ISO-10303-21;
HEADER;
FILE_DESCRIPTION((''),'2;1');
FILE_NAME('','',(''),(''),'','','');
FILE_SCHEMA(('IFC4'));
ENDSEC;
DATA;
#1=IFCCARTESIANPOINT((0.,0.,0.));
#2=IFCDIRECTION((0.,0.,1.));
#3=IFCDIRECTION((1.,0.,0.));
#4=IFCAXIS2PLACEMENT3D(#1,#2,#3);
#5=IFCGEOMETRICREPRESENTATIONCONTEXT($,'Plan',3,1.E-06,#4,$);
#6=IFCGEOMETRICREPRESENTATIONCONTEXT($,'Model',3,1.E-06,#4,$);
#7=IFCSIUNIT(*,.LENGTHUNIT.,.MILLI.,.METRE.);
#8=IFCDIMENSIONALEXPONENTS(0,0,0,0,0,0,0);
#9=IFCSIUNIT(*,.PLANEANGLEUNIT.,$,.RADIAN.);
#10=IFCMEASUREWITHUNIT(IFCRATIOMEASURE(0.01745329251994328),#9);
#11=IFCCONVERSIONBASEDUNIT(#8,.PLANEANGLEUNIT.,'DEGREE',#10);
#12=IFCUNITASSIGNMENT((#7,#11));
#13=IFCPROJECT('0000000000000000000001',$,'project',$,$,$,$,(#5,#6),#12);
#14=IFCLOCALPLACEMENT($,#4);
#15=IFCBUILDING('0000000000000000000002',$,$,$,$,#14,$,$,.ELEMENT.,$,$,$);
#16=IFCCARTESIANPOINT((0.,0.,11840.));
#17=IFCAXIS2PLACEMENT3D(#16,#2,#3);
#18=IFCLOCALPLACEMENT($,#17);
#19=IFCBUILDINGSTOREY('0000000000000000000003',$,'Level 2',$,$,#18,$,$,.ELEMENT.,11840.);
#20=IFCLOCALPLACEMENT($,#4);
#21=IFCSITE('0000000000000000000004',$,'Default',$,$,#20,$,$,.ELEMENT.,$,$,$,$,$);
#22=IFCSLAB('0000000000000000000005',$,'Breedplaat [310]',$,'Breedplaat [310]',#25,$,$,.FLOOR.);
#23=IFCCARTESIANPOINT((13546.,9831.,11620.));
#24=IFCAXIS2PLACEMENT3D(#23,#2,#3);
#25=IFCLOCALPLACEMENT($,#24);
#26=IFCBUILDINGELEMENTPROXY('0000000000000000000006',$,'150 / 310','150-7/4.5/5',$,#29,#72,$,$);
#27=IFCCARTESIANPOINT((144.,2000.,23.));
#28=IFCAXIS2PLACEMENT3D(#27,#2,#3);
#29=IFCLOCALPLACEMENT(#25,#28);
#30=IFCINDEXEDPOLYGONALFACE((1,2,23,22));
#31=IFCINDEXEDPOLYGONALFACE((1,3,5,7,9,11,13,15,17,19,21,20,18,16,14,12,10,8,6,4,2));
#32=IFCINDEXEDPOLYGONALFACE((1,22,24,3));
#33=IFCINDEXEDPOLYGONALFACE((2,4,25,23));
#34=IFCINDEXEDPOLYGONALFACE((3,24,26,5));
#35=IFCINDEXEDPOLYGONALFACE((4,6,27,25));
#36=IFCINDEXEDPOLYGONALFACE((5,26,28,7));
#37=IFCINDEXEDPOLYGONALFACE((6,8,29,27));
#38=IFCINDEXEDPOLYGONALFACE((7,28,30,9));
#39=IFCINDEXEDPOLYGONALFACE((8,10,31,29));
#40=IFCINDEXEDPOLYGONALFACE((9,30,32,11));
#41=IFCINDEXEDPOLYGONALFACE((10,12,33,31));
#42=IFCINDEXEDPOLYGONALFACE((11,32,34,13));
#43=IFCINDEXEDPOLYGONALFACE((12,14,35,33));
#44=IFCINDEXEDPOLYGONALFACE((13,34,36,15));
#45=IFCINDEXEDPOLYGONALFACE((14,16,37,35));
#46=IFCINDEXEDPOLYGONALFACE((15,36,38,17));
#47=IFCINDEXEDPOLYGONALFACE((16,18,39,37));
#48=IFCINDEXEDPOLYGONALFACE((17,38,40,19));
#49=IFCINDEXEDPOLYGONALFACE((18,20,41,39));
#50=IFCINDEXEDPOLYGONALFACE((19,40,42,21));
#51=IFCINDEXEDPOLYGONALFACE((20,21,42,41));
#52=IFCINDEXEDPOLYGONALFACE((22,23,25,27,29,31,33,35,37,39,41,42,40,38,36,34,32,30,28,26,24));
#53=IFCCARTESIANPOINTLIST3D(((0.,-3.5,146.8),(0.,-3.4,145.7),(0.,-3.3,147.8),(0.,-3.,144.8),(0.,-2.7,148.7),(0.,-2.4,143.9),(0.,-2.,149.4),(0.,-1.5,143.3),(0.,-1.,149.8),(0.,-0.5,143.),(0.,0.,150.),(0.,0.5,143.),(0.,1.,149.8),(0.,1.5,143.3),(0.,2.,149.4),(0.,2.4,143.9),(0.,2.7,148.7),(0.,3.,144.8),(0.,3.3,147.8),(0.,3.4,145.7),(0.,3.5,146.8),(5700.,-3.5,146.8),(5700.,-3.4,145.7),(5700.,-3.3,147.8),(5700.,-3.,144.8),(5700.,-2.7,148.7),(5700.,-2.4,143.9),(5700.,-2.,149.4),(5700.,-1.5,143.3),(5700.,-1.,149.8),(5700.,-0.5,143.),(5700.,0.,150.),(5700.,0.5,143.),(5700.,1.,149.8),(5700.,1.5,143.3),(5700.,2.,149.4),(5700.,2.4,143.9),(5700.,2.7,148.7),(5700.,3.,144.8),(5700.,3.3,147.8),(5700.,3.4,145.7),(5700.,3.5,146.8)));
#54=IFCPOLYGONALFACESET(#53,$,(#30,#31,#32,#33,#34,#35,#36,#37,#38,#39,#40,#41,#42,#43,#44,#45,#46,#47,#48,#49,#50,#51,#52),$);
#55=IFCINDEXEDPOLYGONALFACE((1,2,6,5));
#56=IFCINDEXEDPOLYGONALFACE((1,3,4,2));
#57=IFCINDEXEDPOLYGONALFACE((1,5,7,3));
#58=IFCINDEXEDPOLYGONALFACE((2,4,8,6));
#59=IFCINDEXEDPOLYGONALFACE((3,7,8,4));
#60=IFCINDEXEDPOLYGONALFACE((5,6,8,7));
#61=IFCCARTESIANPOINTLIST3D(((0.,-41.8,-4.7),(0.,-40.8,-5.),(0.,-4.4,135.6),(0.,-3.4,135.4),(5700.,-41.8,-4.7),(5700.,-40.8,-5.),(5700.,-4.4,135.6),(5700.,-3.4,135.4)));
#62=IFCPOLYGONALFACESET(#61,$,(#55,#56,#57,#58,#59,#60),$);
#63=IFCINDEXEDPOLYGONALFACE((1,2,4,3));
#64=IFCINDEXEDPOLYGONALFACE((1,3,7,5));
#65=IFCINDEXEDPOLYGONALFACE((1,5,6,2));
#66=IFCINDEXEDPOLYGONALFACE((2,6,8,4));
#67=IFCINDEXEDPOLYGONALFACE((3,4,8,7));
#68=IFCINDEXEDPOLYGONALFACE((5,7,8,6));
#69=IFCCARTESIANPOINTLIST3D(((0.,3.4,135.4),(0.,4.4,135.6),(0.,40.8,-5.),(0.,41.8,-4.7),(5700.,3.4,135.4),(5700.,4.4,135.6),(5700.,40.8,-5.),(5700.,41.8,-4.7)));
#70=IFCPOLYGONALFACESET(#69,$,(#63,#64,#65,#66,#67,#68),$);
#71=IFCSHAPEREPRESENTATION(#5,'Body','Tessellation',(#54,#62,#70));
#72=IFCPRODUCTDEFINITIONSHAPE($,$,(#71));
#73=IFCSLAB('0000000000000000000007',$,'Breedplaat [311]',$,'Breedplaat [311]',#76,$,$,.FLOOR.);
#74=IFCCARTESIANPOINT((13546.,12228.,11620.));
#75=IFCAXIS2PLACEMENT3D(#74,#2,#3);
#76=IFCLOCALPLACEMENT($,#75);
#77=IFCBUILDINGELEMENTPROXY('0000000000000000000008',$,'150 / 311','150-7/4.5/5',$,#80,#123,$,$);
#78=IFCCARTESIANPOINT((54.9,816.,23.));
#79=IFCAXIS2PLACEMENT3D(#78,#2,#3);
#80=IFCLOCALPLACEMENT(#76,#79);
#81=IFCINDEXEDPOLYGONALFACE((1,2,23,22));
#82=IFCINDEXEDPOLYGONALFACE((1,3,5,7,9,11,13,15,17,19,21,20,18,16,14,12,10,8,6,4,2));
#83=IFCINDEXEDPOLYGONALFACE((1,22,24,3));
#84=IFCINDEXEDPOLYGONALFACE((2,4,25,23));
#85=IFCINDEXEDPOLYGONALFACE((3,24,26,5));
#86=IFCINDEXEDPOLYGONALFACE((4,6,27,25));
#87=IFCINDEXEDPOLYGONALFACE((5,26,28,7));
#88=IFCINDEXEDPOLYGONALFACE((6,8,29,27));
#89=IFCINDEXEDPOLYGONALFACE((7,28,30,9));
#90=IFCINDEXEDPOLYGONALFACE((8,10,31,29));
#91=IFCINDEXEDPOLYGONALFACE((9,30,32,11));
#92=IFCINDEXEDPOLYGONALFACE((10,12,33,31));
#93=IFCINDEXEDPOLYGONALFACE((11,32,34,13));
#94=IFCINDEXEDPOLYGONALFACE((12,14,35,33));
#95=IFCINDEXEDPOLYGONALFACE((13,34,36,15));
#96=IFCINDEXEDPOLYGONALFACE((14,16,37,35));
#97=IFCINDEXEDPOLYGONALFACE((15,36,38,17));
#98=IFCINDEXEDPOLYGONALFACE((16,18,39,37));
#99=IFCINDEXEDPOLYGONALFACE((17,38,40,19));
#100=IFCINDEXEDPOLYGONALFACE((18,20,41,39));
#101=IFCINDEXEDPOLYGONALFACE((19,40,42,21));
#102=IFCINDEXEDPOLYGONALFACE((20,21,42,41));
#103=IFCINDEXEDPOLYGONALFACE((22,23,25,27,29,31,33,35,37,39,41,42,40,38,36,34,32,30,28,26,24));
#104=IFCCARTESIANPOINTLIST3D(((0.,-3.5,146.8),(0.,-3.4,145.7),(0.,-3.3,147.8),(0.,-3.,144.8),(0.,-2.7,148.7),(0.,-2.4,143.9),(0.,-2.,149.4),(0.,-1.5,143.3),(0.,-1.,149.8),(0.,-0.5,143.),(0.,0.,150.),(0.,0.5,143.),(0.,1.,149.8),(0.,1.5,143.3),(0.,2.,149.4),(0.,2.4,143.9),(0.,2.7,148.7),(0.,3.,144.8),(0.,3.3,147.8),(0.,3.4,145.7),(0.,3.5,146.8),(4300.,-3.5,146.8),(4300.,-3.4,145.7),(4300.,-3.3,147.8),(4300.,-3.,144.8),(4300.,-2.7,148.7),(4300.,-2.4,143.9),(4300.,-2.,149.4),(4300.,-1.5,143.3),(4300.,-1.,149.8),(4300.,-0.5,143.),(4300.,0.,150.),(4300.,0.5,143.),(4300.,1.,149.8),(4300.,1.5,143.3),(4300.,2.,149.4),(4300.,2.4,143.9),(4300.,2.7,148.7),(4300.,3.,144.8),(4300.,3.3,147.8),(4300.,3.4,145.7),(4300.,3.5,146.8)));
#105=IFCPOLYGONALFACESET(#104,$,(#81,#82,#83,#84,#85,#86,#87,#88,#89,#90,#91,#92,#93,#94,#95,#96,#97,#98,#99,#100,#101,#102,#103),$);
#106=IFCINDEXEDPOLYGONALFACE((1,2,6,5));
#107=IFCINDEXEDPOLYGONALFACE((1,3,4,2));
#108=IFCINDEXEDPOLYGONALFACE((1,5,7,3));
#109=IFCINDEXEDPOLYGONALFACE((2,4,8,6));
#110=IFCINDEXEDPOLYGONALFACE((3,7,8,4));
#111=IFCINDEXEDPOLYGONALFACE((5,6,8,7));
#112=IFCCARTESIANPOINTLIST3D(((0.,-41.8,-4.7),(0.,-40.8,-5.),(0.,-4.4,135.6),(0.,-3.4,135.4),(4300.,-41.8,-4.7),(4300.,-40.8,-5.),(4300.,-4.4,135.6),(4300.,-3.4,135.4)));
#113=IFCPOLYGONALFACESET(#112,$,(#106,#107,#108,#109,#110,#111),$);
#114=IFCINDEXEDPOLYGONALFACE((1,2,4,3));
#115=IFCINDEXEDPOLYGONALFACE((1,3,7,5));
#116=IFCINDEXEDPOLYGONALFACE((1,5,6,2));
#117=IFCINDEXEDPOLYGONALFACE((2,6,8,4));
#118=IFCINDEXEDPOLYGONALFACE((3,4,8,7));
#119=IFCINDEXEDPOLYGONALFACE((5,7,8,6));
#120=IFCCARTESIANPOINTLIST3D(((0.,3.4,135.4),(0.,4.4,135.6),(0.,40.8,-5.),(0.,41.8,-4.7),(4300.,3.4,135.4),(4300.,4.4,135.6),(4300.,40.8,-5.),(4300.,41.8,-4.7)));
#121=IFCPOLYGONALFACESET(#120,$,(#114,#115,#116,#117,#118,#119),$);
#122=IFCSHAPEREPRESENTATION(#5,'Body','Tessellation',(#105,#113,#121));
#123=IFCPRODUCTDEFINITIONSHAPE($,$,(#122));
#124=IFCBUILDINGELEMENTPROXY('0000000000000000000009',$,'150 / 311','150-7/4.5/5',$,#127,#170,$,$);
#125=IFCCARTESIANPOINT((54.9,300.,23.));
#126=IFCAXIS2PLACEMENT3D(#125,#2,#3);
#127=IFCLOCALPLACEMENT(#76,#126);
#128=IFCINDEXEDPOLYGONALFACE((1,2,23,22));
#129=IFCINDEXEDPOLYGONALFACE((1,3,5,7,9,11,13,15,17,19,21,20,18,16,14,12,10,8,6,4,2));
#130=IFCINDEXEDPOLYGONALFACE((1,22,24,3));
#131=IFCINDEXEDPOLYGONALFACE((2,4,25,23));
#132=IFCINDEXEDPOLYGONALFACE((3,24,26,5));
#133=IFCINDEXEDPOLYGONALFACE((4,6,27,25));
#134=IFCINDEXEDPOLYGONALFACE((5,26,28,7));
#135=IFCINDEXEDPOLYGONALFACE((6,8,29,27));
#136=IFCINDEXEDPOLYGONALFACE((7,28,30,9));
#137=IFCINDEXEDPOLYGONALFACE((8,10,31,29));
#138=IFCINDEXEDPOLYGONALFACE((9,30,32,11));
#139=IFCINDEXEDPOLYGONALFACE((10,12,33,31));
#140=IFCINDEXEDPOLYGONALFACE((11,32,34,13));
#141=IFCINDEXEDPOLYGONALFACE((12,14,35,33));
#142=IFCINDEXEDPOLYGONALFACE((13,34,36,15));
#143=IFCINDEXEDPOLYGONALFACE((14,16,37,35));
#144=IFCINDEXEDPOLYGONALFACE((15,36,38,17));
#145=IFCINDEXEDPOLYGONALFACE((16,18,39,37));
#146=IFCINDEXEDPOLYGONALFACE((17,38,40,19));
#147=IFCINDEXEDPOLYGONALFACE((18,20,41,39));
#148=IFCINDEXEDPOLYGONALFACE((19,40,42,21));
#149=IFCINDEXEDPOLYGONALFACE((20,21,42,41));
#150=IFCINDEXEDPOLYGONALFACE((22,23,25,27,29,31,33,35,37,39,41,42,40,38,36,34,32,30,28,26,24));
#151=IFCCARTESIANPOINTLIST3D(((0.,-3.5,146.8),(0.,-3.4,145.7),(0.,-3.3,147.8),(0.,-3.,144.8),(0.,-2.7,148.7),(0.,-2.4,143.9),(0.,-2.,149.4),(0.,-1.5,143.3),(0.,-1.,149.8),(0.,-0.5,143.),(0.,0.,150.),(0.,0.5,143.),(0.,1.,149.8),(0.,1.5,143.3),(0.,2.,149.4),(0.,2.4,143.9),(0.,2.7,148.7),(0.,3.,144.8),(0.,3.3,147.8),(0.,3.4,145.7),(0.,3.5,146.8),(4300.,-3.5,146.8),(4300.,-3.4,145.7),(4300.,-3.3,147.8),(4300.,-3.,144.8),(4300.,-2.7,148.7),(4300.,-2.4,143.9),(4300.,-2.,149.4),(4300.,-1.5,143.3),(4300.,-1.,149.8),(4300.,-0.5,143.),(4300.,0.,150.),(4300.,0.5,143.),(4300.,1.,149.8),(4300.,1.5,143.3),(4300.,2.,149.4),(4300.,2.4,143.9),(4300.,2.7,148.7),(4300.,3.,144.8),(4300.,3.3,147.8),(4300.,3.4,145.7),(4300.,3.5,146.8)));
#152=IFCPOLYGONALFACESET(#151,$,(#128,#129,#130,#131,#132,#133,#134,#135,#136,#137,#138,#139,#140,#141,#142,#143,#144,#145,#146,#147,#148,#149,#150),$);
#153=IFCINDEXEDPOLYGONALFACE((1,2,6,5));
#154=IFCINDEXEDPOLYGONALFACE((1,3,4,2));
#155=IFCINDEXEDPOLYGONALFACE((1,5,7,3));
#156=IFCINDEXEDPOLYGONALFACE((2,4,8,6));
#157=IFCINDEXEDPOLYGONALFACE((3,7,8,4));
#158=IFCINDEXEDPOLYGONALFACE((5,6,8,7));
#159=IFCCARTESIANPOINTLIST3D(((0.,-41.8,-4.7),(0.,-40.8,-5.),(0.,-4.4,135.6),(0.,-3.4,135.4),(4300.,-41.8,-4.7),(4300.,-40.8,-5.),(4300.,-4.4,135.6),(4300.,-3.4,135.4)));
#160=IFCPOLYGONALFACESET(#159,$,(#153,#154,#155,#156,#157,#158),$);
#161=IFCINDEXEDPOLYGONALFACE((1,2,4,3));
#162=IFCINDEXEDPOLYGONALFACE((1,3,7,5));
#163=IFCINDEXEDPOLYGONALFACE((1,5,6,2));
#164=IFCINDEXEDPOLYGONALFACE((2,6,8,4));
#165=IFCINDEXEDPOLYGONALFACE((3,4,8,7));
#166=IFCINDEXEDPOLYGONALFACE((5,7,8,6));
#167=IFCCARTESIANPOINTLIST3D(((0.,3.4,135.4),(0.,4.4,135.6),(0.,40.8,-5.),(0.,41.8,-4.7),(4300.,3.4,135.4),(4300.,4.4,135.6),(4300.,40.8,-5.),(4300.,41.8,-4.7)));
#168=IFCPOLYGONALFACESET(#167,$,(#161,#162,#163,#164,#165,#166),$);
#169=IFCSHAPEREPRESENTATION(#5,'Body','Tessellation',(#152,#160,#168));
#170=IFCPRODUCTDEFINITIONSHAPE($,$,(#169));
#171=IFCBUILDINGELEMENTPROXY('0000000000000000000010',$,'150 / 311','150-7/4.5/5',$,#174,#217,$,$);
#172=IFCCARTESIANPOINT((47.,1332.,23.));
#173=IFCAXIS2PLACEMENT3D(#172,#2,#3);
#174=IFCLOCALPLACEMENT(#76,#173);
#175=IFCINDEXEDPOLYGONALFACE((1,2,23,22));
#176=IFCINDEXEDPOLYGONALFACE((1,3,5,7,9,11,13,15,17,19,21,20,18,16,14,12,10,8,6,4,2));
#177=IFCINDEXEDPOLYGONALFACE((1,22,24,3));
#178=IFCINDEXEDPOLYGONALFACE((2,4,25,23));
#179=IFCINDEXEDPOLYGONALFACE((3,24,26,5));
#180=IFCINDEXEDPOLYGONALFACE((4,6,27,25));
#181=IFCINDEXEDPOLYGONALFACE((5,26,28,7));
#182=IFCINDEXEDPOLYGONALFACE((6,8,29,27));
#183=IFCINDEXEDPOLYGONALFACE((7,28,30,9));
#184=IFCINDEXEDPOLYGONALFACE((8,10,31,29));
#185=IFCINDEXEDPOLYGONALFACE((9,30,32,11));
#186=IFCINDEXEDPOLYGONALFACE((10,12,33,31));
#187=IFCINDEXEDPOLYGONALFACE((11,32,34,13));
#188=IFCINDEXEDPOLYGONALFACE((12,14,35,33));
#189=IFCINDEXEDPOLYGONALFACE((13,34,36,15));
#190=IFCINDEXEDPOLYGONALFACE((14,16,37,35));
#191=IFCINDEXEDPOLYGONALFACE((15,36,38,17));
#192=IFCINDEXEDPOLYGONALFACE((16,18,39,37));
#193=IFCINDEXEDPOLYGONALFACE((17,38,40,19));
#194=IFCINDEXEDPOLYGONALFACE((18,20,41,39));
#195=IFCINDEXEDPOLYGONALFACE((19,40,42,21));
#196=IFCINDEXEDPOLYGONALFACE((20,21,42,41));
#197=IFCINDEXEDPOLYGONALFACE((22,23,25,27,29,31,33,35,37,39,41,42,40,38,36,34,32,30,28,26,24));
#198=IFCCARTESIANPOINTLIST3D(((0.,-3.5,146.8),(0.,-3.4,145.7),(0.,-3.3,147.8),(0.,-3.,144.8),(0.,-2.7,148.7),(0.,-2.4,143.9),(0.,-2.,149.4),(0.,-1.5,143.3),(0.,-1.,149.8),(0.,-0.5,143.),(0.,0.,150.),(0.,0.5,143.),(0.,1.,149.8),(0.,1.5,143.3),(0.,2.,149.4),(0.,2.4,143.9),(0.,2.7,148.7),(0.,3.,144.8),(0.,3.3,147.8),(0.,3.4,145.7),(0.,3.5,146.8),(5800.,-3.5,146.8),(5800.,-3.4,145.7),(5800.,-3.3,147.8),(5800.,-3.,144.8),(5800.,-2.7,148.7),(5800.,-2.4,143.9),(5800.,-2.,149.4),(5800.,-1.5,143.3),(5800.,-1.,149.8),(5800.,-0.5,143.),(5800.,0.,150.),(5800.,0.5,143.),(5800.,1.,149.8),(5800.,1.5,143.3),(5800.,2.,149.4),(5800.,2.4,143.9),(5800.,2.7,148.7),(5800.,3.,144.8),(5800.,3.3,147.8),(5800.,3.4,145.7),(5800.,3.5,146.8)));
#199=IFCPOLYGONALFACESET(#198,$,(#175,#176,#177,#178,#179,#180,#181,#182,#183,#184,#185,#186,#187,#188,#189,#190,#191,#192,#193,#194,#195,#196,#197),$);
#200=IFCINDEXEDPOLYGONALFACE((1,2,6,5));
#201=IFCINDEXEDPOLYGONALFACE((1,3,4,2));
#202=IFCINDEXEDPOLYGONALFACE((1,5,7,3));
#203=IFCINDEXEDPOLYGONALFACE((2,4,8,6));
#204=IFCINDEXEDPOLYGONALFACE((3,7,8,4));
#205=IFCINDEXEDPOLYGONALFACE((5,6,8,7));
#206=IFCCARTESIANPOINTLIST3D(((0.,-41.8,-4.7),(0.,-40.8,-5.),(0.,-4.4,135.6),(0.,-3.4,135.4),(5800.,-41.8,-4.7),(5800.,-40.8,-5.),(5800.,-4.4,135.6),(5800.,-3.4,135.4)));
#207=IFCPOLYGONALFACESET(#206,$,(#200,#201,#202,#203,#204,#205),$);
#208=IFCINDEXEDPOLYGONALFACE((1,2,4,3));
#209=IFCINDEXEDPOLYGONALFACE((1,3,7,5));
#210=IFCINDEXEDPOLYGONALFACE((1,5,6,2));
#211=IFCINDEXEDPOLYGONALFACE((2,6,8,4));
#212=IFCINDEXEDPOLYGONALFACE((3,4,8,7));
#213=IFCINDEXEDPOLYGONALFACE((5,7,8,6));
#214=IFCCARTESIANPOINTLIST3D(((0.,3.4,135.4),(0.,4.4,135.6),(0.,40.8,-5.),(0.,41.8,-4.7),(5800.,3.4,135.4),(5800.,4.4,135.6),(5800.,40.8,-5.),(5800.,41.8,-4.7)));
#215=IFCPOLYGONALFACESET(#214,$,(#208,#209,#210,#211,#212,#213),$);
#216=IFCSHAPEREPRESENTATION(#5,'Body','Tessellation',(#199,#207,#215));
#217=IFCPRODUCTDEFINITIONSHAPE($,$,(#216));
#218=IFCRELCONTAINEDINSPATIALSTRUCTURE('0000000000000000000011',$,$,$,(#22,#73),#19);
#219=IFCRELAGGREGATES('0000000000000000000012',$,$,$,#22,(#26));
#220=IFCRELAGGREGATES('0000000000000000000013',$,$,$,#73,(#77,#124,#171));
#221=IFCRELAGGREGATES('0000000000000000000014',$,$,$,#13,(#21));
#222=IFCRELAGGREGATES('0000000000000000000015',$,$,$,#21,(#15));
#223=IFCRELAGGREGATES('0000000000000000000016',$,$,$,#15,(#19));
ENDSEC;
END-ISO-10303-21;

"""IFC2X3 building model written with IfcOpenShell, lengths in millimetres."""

from ifc_helpers import new_model, entity, si_unit, converted_unit, frame, origin_with_axes, origin_2d_with_axis, place, context, project, spatial, rectangle, circle, extrude, element, aggregate, save


model = new_model("IFC2X3")

# Units and contexts
plan_context = context("Plan", 3, precision=1e-06, world=origin_with_axes())
model_context = context("Model", 3, precision=1e-06, world=origin_with_axes())
ifc_project = project(units=[si_unit("LENGTHUNIT", "METRE", prefix="MILLI"), converted_unit("PLANEANGLEUNIT", "DEGREE", entity("IfcRatioMeasure", 0.01745329251994328), si_unit("PLANEANGLEUNIT", "RADIAN"), dimensions=[0, 0, 0, 0, 0, 0, 0])], contexts=[plan_context, model_context])

# Site, building, storey
site_placement = place(None, origin_with_axes())
site = spatial("IfcSite", under=ifc_project, at=site_placement, Name="Default", CompositionType="ELEMENT")
building_placement = place(None, origin_with_axes())
building = spatial("IfcBuilding", under=site, at=building_placement, CompositionType="ELEMENT")
storey_placement = place(None, frame((0.0, 0.0, 11840.0), z_axis=(0.0, 0.0, 1.0), x_axis=(1.0, 0.0, 0.0)))
storey = spatial("IfcBuildingStorey", under=building, at=storey_placement, Name="Level 2", CompositionType="ELEMENT", Elevation=11840.0)

# Slabs, building element proxies
slab_1_placement = place(None, frame((13546.0, 9831.0, 11620.0), z_axis=(0.0, 0.0, 1.0), x_axis=(1.0, 0.0, 0.0)))
slab_1 = element("IfcSlab", 1, at=slab_1_placement, inside=storey, Name="Breedplaat [310]", ObjectType="Breedplaat [310]", PredefinedType="FLOOR")
proxy_1_placement = place(slab_1_placement, frame((144.0, 2000.0, 23.0), z_axis=(0.0, 0.0, 1.0), x_axis=(1.0, 0.0, 0.0)))
proxy_1 = element("IfcBuildingElementProxy", 2, at=proxy_1_placement, Name="150 / 310", Description="150-7/4.5/5", context=plan_context, shape_type="SweptSolid", body=[
    extrude(circle(Radius=3.5, at=origin_2d_with_axis()), frame((0.0, 0.0, 146.5), z_axis=(1.0, 0.0, 0.0), x_axis=(0.0, 0.0, 1.0)), (0.0, 0.0, 1.0), 5700.0),
    extrude(rectangle(XDim=145.2, YDim=1.0, at=origin_2d_with_axis()), frame((0.0, -22.6, 65.3), z_axis=(1.0, 0.0, 0.0), x_axis=(0.0, 0.257663, 0.966235)), (0.0, 0.0, 1.0), 5700.0),
    extrude(rectangle(XDim=145.2, YDim=1.0, at=origin_2d_with_axis()), frame((0.0, 22.6, 65.3), z_axis=(1.0, 0.0, 0.0), x_axis=(0.0, -0.257663, 0.966235)), (0.0, 0.0, 1.0), 5700.0),
])
aggregate(slab_1, [proxy_1])
slab_2_placement = place(None, frame((13546.0, 12228.0, 11620.0), z_axis=(0.0, 0.0, 1.0), x_axis=(1.0, 0.0, 0.0)))
slab_2 = element("IfcSlab", 3, at=slab_2_placement, inside=storey, Name="Breedplaat [311]", ObjectType="Breedplaat [311]", PredefinedType="FLOOR")
proxy_2_placement = place(slab_2_placement, frame((54.9, 816.0, 23.0), z_axis=(0.0, 0.0, 1.0), x_axis=(1.0, 0.0, 0.0)))
proxy_2 = element("IfcBuildingElementProxy", 4, at=proxy_2_placement, Name="150 / 311", Description="150-7/4.5/5", context=plan_context, shape_type="SweptSolid", body=[
    extrude(circle(Radius=3.5, at=origin_2d_with_axis()), frame((0.0, 0.0, 146.5), z_axis=(1.0, 0.0, 0.0), x_axis=(0.0, 0.0, 1.0)), (0.0, 0.0, 1.0), 4300.0),
    extrude(rectangle(XDim=145.2, YDim=1.0, at=origin_2d_with_axis()), frame((0.0, -22.6, 65.3), z_axis=(1.0, 0.0, 0.0), x_axis=(0.0, 0.257663, 0.966235)), (0.0, 0.0, 1.0), 4300.0),
    extrude(rectangle(XDim=145.2, YDim=1.0, at=origin_2d_with_axis()), frame((0.0, 22.6, 65.3), z_axis=(1.0, 0.0, 0.0), x_axis=(0.0, -0.257663, 0.966235)), (0.0, 0.0, 1.0), 4300.0),
])
proxy_3_placement = place(slab_2_placement, frame((54.9, 300.0, 23.0), z_axis=(0.0, 0.0, 1.0), x_axis=(1.0, 0.0, 0.0)))
proxy_3 = element("IfcBuildingElementProxy", 5, at=proxy_3_placement, Name="150 / 311", Description="150-7/4.5/5", context=plan_context, shape_type="SweptSolid", body=[
    extrude(circle(Radius=3.5, at=origin_2d_with_axis()), frame((0.0, 0.0, 146.5), z_axis=(1.0, 0.0, 0.0), x_axis=(0.0, 0.0, 1.0)), (0.0, 0.0, 1.0), 4300.0),
    extrude(rectangle(XDim=145.2, YDim=1.0, at=origin_2d_with_axis()), frame((0.0, -22.6, 65.3), z_axis=(1.0, 0.0, 0.0), x_axis=(0.0, 0.257663, 0.966235)), (0.0, 0.0, 1.0), 4300.0),
    extrude(rectangle(XDim=145.2, YDim=1.0, at=origin_2d_with_axis()), frame((0.0, 22.6, 65.3), z_axis=(1.0, 0.0, 0.0), x_axis=(0.0, -0.257663, 0.966235)), (0.0, 0.0, 1.0), 4300.0),
])
proxy_4_placement = place(slab_2_placement, frame((47.0, 1332.0, 23.0), z_axis=(0.0, 0.0, 1.0), x_axis=(1.0, 0.0, 0.0)))
proxy_4 = element("IfcBuildingElementProxy", 6, at=proxy_4_placement, Name="150 / 311", Description="150-7/4.5/5", context=plan_context, shape_type="SweptSolid", body=[
    extrude(circle(Radius=3.5, at=origin_2d_with_axis()), frame((0.0, 0.0, 146.5), z_axis=(1.0, 0.0, 0.0), x_axis=(0.0, 0.0, 1.0)), (0.0, 0.0, 1.0), 5800.0),
    extrude(rectangle(XDim=145.2, YDim=1.0, at=origin_2d_with_axis()), frame((0.0, -22.6, 65.3), z_axis=(1.0, 0.0, 0.0), x_axis=(0.0, 0.257663, 0.966235)), (0.0, 0.0, 1.0), 5800.0),
    extrude(rectangle(XDim=145.2, YDim=1.0, at=origin_2d_with_axis()), frame((0.0, 22.6, 65.3), z_axis=(1.0, 0.0, 0.0), x_axis=(0.0, -0.257663, 0.966235)), (0.0, 0.0, 1.0), 5800.0),
])
aggregate(slab_2, [proxy_2, proxy_3, proxy_4])

save(model, "model.ifc")
